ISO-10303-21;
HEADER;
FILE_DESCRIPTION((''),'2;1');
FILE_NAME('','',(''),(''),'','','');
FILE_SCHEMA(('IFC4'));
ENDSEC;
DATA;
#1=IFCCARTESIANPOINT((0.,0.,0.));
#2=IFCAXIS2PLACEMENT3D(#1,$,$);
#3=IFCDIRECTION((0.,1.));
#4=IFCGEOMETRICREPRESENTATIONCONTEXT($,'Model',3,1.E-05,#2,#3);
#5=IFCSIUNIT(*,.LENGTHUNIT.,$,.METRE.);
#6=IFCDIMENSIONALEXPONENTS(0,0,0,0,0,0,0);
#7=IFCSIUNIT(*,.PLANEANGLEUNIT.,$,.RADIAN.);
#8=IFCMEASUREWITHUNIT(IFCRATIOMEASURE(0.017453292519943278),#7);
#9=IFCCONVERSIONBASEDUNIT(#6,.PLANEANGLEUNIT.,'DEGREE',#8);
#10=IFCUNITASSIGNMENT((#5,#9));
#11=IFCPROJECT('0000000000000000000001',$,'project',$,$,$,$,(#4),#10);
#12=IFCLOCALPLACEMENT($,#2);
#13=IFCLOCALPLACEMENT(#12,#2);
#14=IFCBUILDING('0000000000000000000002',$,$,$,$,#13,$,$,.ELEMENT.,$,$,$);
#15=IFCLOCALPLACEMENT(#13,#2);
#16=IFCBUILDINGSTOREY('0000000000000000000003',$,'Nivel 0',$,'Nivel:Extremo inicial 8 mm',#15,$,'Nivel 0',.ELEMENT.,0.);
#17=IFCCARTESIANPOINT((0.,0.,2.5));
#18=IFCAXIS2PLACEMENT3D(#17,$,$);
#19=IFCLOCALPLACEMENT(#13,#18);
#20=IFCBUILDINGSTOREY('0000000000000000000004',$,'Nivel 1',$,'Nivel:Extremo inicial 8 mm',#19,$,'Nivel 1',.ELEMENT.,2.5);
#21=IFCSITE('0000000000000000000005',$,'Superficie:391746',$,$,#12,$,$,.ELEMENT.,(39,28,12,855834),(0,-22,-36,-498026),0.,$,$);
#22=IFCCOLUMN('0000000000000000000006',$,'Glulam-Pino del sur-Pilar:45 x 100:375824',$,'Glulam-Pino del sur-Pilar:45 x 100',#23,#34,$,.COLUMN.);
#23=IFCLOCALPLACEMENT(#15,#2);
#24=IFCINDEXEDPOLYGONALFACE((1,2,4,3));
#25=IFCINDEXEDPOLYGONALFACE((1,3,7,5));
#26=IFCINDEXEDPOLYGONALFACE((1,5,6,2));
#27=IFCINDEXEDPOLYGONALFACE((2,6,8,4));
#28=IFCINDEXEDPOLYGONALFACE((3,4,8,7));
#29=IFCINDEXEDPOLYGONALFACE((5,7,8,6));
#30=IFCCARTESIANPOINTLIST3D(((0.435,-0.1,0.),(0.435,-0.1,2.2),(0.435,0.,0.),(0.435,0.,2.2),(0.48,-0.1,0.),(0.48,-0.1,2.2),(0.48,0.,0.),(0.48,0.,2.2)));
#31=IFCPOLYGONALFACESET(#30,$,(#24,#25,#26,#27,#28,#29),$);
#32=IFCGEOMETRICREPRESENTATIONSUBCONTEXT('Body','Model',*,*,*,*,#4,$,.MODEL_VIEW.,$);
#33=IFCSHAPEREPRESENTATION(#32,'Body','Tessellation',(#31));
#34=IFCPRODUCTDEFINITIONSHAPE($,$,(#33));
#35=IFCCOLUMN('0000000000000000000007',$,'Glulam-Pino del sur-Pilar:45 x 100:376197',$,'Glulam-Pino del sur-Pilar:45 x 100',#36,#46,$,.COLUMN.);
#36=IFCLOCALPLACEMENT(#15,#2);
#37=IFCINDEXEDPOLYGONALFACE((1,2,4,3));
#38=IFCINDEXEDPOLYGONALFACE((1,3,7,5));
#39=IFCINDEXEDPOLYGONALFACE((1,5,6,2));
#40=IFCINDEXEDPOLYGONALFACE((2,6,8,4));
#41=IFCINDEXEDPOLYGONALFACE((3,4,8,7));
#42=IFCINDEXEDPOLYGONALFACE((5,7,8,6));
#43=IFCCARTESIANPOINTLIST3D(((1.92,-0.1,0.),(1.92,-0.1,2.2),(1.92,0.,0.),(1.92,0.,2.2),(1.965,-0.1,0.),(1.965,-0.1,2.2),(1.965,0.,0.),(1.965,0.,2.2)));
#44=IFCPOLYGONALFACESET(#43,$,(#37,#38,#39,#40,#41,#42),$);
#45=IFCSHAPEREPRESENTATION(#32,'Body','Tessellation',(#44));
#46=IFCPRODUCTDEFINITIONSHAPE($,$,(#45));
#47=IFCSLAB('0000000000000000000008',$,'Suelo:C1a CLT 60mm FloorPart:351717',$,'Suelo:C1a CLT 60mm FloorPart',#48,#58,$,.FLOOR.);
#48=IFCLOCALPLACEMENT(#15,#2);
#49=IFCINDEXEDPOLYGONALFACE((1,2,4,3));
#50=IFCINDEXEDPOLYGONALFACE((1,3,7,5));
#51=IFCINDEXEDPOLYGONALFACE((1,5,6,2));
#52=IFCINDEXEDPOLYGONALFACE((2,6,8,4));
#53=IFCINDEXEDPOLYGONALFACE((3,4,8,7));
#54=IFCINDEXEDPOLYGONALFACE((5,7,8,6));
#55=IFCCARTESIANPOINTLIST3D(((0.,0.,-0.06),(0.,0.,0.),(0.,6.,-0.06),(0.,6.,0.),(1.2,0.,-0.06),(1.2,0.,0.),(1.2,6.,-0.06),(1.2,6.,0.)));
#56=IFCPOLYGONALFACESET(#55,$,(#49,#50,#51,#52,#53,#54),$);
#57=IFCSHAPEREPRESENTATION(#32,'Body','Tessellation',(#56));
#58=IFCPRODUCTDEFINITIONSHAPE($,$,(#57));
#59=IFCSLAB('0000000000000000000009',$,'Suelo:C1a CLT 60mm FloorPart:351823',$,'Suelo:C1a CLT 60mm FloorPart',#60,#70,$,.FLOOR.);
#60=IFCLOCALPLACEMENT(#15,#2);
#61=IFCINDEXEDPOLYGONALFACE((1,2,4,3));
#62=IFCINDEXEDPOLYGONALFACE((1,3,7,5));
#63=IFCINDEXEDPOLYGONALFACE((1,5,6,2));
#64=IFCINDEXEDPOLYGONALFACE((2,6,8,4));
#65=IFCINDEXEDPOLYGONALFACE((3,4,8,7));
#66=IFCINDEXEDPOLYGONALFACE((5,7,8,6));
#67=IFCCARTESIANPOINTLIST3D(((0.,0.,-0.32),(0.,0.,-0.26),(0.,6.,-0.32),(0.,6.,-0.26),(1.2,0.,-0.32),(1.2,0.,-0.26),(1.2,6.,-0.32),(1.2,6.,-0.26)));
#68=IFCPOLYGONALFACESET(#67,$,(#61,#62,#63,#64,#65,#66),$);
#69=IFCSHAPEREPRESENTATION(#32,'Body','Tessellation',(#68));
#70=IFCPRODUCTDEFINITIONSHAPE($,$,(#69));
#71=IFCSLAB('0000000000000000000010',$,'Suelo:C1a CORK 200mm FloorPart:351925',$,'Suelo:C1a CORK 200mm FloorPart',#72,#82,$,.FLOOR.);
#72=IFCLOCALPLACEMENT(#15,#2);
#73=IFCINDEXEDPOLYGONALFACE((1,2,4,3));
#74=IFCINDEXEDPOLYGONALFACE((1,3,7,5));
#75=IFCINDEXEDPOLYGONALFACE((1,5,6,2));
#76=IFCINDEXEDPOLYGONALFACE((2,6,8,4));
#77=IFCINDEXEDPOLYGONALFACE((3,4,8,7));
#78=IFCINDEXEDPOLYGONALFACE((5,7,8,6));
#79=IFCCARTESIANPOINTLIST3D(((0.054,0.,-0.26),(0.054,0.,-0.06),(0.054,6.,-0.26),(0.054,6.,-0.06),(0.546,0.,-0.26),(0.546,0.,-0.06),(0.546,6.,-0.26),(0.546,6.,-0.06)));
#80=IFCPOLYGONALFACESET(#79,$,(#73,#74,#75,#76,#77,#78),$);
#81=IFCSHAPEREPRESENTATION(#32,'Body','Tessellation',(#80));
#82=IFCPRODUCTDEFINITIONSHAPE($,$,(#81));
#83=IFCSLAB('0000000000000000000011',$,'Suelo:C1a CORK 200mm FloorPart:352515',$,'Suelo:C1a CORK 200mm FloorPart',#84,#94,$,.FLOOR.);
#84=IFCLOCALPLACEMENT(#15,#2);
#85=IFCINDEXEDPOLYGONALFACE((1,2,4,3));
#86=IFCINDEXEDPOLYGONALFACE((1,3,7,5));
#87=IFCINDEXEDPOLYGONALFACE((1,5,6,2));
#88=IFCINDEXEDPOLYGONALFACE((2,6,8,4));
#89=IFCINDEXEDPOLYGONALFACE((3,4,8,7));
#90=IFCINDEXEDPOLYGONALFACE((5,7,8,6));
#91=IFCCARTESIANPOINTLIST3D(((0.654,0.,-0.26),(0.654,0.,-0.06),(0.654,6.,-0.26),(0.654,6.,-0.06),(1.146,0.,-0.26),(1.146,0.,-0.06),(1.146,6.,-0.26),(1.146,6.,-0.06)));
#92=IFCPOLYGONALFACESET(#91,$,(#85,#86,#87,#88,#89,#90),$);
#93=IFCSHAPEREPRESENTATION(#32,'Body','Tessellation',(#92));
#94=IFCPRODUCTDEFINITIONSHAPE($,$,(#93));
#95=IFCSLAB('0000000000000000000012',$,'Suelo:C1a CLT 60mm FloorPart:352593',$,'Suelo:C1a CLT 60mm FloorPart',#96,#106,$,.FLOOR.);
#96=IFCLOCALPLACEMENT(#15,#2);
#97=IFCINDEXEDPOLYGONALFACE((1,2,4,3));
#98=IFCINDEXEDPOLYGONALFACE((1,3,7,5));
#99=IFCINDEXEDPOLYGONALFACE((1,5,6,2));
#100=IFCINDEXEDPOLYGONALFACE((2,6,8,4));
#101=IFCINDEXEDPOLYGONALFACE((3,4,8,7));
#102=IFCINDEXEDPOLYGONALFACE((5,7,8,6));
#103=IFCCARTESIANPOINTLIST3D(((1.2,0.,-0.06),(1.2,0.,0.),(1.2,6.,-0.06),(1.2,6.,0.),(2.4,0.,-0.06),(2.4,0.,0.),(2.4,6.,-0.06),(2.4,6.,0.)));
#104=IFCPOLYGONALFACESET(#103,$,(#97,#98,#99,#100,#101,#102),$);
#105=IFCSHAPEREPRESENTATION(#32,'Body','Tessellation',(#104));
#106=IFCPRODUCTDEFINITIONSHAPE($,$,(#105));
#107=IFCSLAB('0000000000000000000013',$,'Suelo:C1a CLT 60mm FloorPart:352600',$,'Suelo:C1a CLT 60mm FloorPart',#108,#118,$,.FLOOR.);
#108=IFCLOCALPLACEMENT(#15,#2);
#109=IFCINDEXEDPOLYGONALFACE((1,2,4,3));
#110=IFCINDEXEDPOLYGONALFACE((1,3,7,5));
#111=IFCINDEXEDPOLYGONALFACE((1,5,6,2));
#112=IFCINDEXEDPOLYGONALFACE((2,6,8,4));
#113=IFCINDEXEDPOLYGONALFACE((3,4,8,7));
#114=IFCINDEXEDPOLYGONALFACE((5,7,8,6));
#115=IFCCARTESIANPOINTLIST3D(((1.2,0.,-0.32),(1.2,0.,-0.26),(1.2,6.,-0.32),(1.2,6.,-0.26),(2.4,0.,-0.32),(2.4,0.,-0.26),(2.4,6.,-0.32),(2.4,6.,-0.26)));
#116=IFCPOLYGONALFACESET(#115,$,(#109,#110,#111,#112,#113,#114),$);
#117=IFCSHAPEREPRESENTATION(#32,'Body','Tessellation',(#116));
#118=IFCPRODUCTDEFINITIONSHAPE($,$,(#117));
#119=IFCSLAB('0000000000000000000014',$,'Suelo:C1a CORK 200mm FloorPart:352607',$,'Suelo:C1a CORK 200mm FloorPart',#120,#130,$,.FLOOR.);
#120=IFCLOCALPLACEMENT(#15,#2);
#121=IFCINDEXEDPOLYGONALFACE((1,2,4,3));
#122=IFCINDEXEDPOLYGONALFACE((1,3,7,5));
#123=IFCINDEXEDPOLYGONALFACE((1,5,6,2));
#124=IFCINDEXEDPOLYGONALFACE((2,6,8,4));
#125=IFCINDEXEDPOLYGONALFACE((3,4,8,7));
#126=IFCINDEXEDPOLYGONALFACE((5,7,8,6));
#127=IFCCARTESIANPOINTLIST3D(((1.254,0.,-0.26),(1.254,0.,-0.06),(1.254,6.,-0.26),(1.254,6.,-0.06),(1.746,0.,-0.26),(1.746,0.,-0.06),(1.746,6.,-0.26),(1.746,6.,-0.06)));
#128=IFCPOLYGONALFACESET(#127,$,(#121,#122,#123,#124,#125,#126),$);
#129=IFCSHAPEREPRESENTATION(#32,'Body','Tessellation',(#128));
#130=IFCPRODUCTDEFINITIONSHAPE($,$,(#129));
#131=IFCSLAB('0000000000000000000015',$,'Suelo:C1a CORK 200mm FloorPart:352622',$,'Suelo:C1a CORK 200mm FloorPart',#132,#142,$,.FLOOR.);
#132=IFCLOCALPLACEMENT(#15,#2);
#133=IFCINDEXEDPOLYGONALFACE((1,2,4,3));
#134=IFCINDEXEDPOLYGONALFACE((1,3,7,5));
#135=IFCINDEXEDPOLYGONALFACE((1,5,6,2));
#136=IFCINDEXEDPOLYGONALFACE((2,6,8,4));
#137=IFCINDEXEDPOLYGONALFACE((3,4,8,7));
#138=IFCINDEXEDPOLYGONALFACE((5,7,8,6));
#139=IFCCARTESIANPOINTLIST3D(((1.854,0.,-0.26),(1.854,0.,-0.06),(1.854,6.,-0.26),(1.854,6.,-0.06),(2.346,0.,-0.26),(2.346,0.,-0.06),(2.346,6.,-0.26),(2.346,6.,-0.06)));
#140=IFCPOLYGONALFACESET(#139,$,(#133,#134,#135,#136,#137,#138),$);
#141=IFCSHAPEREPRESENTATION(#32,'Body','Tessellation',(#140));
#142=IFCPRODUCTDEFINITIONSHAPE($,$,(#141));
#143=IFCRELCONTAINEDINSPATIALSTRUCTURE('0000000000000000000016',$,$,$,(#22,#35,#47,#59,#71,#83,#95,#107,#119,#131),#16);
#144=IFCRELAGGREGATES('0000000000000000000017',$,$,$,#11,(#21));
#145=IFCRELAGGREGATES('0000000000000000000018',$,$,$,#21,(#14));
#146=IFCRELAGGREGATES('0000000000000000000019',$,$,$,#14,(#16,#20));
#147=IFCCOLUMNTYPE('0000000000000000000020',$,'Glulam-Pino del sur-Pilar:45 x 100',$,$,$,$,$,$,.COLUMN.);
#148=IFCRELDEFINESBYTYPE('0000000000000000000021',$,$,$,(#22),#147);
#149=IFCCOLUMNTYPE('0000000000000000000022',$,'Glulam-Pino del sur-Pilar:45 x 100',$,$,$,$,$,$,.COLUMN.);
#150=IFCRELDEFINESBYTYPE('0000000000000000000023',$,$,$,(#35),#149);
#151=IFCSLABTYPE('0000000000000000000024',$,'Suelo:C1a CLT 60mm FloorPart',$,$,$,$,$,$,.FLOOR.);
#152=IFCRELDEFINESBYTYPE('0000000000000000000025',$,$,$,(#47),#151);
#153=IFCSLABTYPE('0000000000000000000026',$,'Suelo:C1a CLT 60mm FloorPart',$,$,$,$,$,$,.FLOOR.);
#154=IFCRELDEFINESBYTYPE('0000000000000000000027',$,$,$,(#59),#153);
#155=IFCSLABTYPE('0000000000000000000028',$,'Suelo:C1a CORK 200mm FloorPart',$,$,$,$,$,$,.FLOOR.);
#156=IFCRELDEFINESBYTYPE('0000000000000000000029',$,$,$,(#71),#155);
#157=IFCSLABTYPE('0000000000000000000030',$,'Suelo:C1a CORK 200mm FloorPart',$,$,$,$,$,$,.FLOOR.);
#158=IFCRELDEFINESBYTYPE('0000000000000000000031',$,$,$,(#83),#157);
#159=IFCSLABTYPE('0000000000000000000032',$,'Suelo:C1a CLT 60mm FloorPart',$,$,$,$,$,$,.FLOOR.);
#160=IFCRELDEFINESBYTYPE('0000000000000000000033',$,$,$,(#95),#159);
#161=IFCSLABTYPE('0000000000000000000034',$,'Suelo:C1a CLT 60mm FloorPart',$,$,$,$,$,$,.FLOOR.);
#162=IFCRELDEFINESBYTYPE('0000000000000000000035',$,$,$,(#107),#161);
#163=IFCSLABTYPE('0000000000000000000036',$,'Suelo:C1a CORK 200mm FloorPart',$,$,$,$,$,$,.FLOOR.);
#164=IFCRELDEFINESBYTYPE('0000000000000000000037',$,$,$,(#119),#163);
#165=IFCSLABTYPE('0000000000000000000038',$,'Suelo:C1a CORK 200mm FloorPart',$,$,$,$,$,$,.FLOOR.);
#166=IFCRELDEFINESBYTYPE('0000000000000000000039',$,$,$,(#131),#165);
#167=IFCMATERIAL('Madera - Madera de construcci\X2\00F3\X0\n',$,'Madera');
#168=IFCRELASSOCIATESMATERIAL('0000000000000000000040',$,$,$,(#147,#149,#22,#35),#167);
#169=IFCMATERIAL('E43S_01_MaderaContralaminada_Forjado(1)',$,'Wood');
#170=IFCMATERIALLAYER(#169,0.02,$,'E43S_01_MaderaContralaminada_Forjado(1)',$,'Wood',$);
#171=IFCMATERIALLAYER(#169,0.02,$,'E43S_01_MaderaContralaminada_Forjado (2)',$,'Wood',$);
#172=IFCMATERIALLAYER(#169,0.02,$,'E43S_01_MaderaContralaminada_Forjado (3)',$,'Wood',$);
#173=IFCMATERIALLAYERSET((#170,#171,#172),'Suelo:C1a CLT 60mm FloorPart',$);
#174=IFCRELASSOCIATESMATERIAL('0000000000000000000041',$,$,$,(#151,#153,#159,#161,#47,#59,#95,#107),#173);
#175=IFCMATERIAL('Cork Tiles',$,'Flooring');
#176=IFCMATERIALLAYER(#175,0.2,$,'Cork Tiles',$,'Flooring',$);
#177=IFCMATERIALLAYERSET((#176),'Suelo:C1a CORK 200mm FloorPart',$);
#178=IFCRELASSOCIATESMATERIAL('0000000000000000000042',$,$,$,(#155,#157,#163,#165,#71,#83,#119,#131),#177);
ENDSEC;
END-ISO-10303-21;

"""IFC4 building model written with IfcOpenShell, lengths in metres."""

from ifc_helpers import new_model, entity, si_unit, converted_unit, direction, frame, frame_2d, origin, origin_2d_with_axis, place, context, subcontext, project, spatial, polyline, segment, composite_curve, rectangle, outline, extrude, source, transform, mapped, material, layer, layer_set, layer_usage, material_profile, profile_set, profile_usage, type_object, type_shapes, element, save


model = new_model("IFC4")

# Units and contexts
model_context = context("Model", 3, precision=1e-05, world=origin(), true_north=direction((0.0, 1.0)))
body_context = subcontext(model_context, "Body", "Model", "MODEL_VIEW")
ifc_project = project(units=[si_unit("LENGTHUNIT", "METRE"), converted_unit("PLANEANGLEUNIT", "DEGREE", entity("IfcRatioMeasure", 0.017453292519943278), si_unit("PLANEANGLEUNIT", "RADIAN"), dimensions=[0, 0, 0, 0, 0, 0, 0])], contexts=[model_context])

# Site, building, storey
site_placement = place(None, origin())
site = spatial("IfcSite", under=ifc_project, at=site_placement, Name="Superficie:391746", CompositionType="ELEMENT", RefLatitude=(39, 28, 12, 855834), RefLongitude=(0, -22, -36, -498026), RefElevation=0.0)
building_placement = place(site_placement, origin())
building = spatial("IfcBuilding", under=site, at=building_placement, CompositionType="ELEMENT")
storey_1_placement = place(building_placement, origin())
storey_1 = spatial("IfcBuildingStorey", under=building, at=storey_1_placement, Name="Nivel 0", ObjectType="Nivel:Extremo inicial 8 mm", LongName="Nivel 0", CompositionType="ELEMENT", Elevation=0.0)

# Columns
ifc_material_1 = material(Name="Madera - Madera de construcción", Category="Madera")
ifc_material_profile_1 = material_profile(ifc_material_1, outline(composite_curve([segment(polyline([(0.0225, 0.05, 0.0), (0.0225, -0.05, 0.0)]), True, "CONTINUOUS"), segment(polyline([(0.0225, -0.05, 0.0), (-0.0225, -0.05, 0.0)]), True, "CONTINUOUS"), segment(polyline([(-0.0225, -0.05, 0.0), (-0.0225, 0.05, 0.0)]), True, "CONTINUOUS"), segment(polyline([(-0.0225, 0.05, 0.0), (0.0225, 0.05, 0.0)]), True, "CONTINUOUS")], self_intersect=False), kind="CURVE"), Name="45 x 100")
ifc_material_profile_2 = material_profile(ifc_material_1, outline(composite_curve([segment(polyline([(0.0225, 0.05, 2.5), (-0.0225, 0.05, 2.5)]), True, "CONTINUOUS"), segment(polyline([(-0.0225, 0.05, 2.5), (-0.0225, -0.05, 2.5)]), True, "CONTINUOUS"), segment(polyline([(-0.0225, -0.05, 2.5), (0.0225, -0.05, 2.5)]), True, "CONTINUOUS"), segment(polyline([(0.0225, -0.05, 2.5), (0.0225, 0.05, 2.5)]), True, "CONTINUOUS")], self_intersect=False), kind="CURVE"), Name="45 x 100")
ifc_profile_set = profile_set([ifc_material_profile_1, ifc_material_profile_2], Name="45 x 100")
ifc_profile_usage_1 = profile_usage(ifc_profile_set)
column_type_1 = type_object("IfcColumnType", Name="Glulam-Pino del sur-Pilar:45 x 100", PredefinedType="COLUMN", material=ifc_profile_set)
shared_shape_1 = source(origin(), body_context, "Body", "SweptSolid", [
    extrude(rectangle(XDim=0.1, YDim=0.045, at=origin_2d_with_axis()), frame((0.0, 0.0, 0.0), z_axis=(0.0, 0.0, 1.0), x_axis=(0.0, -1.0, 0.0)), (0.0, 0.0, 1.0), 2.2),
])
type_shapes(column_type_1, [shared_shape_1])
column_1_placement = place(storey_1_placement, frame((0.4575, -0.05, 0.0), z_axis=(0.0, 0.0, 1.0), x_axis=(-1.0, 0.0, 0.0)))
element("IfcColumn", 1, at=column_1_placement, inside=storey_1, type_object=column_type_1, material=ifc_profile_usage_1, Name="Glulam-Pino del sur-Pilar:45 x 100:375824", ObjectType="Glulam-Pino del sur-Pilar:45 x 100", PredefinedType="COLUMN", context=body_context, shape_type="MappedRepresentation", body=[
    mapped(shared_shape_1, transform((0.0, 0.0, 0.0), scale=1.0)),
])
ifc_profile_usage_2 = profile_usage(ifc_profile_set)
column_type_2 = type_object("IfcColumnType", Name="Glulam-Pino del sur-Pilar:45 x 100", PredefinedType="COLUMN", material=ifc_profile_set)
shared_shape_2 = source(origin(), body_context, "Body", "SweptSolid", [
    extrude(rectangle(XDim=0.1, YDim=0.045, at=origin_2d_with_axis()), frame((0.0, 0.0, 0.0), z_axis=(0.0, 0.0, 1.0), x_axis=(0.0, -1.0, 0.0)), (0.0, 0.0, 1.0), 2.2),
])
type_shapes(column_type_2, [shared_shape_2])
column_2_placement = place(storey_1_placement, frame((1.9425, -0.05, 0.0)))
element("IfcColumn", 2, at=column_2_placement, inside=storey_1, type_object=column_type_2, material=ifc_profile_usage_2, Name="Glulam-Pino del sur-Pilar:45 x 100:376197", ObjectType="Glulam-Pino del sur-Pilar:45 x 100", PredefinedType="COLUMN", context=body_context, shape_type="MappedRepresentation", body=[
    mapped(shared_shape_2, transform((0.0, 0.0, 0.0), scale=1.0)),
])

# Slabs
ifc_material_2 = material(Name="E43S_01_MaderaContralaminada_Forjado(1)", Category="Wood")
ifc_layer_1 = layer(ifc_material_2, 0.02, Name="E43S_01_MaderaContralaminada_Forjado(1)", Category="Wood")
ifc_layer_2 = layer(ifc_material_2, 0.02, Name="E43S_01_MaderaContralaminada_Forjado (2)", Category="Wood")
ifc_layer_3 = layer(ifc_material_2, 0.02, Name="E43S_01_MaderaContralaminada_Forjado (3)", Category="Wood")
ifc_layer_set_1 = layer_set([ifc_layer_1, ifc_layer_2, ifc_layer_3], Name="Suelo:C1a CLT 60mm FloorPart")
ifc_layer_usage_1 = layer_usage(ifc_layer_set_1, "AXIS3", "POSITIVE", 0.0)
slab_type_1 = type_object("IfcSlabType", Name="Suelo:C1a CLT 60mm FloorPart", PredefinedType="FLOOR", material=ifc_layer_set_1)
slab_1_placement = place(storey_1_placement, origin())
element("IfcSlab", 3, at=slab_1_placement, inside=storey_1, type_object=slab_type_1, material=ifc_layer_usage_1, Name="Suelo:C1a CLT 60mm FloorPart:351717", ObjectType="Suelo:C1a CLT 60mm FloorPart", PredefinedType="FLOOR", context=body_context, shape_type="SweptSolid", body=[
    extrude(rectangle(XDim=6.0, YDim=1.2, at=frame_2d((0.0, 0.0), x_axis=(1.0, 0.0))), frame((0.6, 3.0, 0.0), z_axis=(0.0, 0.0, -1.0), x_axis=(0.0, 1.0, 0.0)), (0.0, 0.0, 1.0), 0.06),
])
ifc_layer_usage_2 = layer_usage(ifc_layer_set_1, "AXIS3", "POSITIVE", 0.0)
slab_type_2 = type_object("IfcSlabType", Name="Suelo:C1a CLT 60mm FloorPart", PredefinedType="FLOOR", material=ifc_layer_set_1)
slab_2_placement = place(storey_1_placement, origin())
element("IfcSlab", 4, at=slab_2_placement, inside=storey_1, type_object=slab_type_2, material=ifc_layer_usage_2, Name="Suelo:C1a CLT 60mm FloorPart:351823", ObjectType="Suelo:C1a CLT 60mm FloorPart", PredefinedType="FLOOR", context=body_context, shape_type="SweptSolid", body=[
    extrude(rectangle(XDim=6.0, YDim=1.2, at=frame_2d((0.0, 0.0), x_axis=(1.0, 0.0))), frame((0.6, 3.0, -0.26), z_axis=(0.0, 0.0, -1.0), x_axis=(0.0, 1.0, 0.0)), (0.0, 0.0, 1.0), 0.06),
])
ifc_material_3 = material(Name="Cork Tiles", Category="Flooring")
ifc_layer_4 = layer(ifc_material_3, 0.2, Name="Cork Tiles", Category="Flooring")
ifc_layer_set_2 = layer_set([ifc_layer_4], Name="Suelo:C1a CORK 200mm FloorPart")
ifc_layer_usage_3 = layer_usage(ifc_layer_set_2, "AXIS3", "POSITIVE", 0.0)
slab_type_3 = type_object("IfcSlabType", Name="Suelo:C1a CORK 200mm FloorPart", PredefinedType="FLOOR", material=ifc_layer_set_2)
slab_3_placement = place(storey_1_placement, origin())
element("IfcSlab", 5, at=slab_3_placement, inside=storey_1, type_object=slab_type_3, material=ifc_layer_usage_3, Name="Suelo:C1a CORK 200mm FloorPart:351925", ObjectType="Suelo:C1a CORK 200mm FloorPart", PredefinedType="FLOOR", context=body_context, shape_type="SweptSolid", body=[
    extrude(rectangle(XDim=6.0, YDim=0.492, at=frame_2d((0.0, 0.0), x_axis=(1.0, 0.0))), frame((0.3, 3.0, -0.06), z_axis=(0.0, 0.0, -1.0), x_axis=(0.0, 1.0, 0.0)), (0.0, 0.0, 1.0), 0.2),
])
ifc_layer_usage_4 = layer_usage(ifc_layer_set_2, "AXIS3", "POSITIVE", 0.0)
slab_type_4 = type_object("IfcSlabType", Name="Suelo:C1a CORK 200mm FloorPart", PredefinedType="FLOOR", material=ifc_layer_set_2)
slab_4_placement = place(storey_1_placement, origin())
element("IfcSlab", 6, at=slab_4_placement, inside=storey_1, type_object=slab_type_4, material=ifc_layer_usage_4, Name="Suelo:C1a CORK 200mm FloorPart:352515", ObjectType="Suelo:C1a CORK 200mm FloorPart", PredefinedType="FLOOR", context=body_context, shape_type="SweptSolid", body=[
    extrude(rectangle(XDim=6.0, YDim=0.492, at=frame_2d((0.0, 0.0), x_axis=(1.0, 0.0))), frame((0.9, 3.0, -0.06), z_axis=(0.0, 0.0, -1.0), x_axis=(0.0, 1.0, 0.0)), (0.0, 0.0, 1.0), 0.2),
])
ifc_layer_usage_5 = layer_usage(ifc_layer_set_1, "AXIS3", "POSITIVE", 0.0)
slab_type_5 = type_object("IfcSlabType", Name="Suelo:C1a CLT 60mm FloorPart", PredefinedType="FLOOR", material=ifc_layer_set_1)
slab_5_placement = place(storey_1_placement, origin())
element("IfcSlab", 7, at=slab_5_placement, inside=storey_1, type_object=slab_type_5, material=ifc_layer_usage_5, Name="Suelo:C1a CLT 60mm FloorPart:352593", ObjectType="Suelo:C1a CLT 60mm FloorPart", PredefinedType="FLOOR", context=body_context, shape_type="SweptSolid", body=[
    extrude(rectangle(XDim=6.0, YDim=1.2, at=frame_2d((0.0, 0.0), x_axis=(1.0, 0.0))), frame((1.8, 3.0, 0.0), z_axis=(0.0, 0.0, -1.0), x_axis=(0.0, 1.0, 0.0)), (0.0, 0.0, 1.0), 0.06),
])
ifc_layer_usage_6 = layer_usage(ifc_layer_set_1, "AXIS3", "POSITIVE", 0.0)
slab_type_6 = type_object("IfcSlabType", Name="Suelo:C1a CLT 60mm FloorPart", PredefinedType="FLOOR", material=ifc_layer_set_1)
slab_6_placement = place(storey_1_placement, origin())
element("IfcSlab", 8, at=slab_6_placement, inside=storey_1, type_object=slab_type_6, material=ifc_layer_usage_6, Name="Suelo:C1a CLT 60mm FloorPart:352600", ObjectType="Suelo:C1a CLT 60mm FloorPart", PredefinedType="FLOOR", context=body_context, shape_type="SweptSolid", body=[
    extrude(rectangle(XDim=6.0, YDim=1.2, at=frame_2d((0.0, 0.0), x_axis=(1.0, 0.0))), frame((1.8, 3.0, -0.26), z_axis=(0.0, 0.0, -1.0), x_axis=(0.0, 1.0, 0.0)), (0.0, 0.0, 1.0), 0.06),
])
ifc_layer_usage_7 = layer_usage(ifc_layer_set_2, "AXIS3", "POSITIVE", 0.0)
slab_type_7 = type_object("IfcSlabType", Name="Suelo:C1a CORK 200mm FloorPart", PredefinedType="FLOOR", material=ifc_layer_set_2)
slab_7_placement = place(storey_1_placement, origin())
element("IfcSlab", 9, at=slab_7_placement, inside=storey_1, type_object=slab_type_7, material=ifc_layer_usage_7, Name="Suelo:C1a CORK 200mm FloorPart:352607", ObjectType="Suelo:C1a CORK 200mm FloorPart", PredefinedType="FLOOR", context=body_context, shape_type="SweptSolid", body=[
    extrude(rectangle(XDim=6.0, YDim=0.492, at=frame_2d((0.0, 0.0), x_axis=(1.0, 0.0))), frame((1.5, 3.0, -0.06), z_axis=(0.0, 0.0, -1.0), x_axis=(0.0, 1.0, 0.0)), (0.0, 0.0, 1.0), 0.2),
])
ifc_layer_usage_8 = layer_usage(ifc_layer_set_2, "AXIS3", "POSITIVE", 0.0)
slab_type_8 = type_object("IfcSlabType", Name="Suelo:C1a CORK 200mm FloorPart", PredefinedType="FLOOR", material=ifc_layer_set_2)
slab_8_placement = place(storey_1_placement, origin())
element("IfcSlab", 10, at=slab_8_placement, inside=storey_1, type_object=slab_type_8, material=ifc_layer_usage_8, Name="Suelo:C1a CORK 200mm FloorPart:352622", ObjectType="Suelo:C1a CORK 200mm FloorPart", PredefinedType="FLOOR", context=body_context, shape_type="SweptSolid", body=[
    extrude(rectangle(XDim=6.0, YDim=0.492, at=frame_2d((0.0, 0.0), x_axis=(1.0, 0.0))), frame((2.1, 3.0, -0.06), z_axis=(0.0, 0.0, -1.0), x_axis=(0.0, 1.0, 0.0)), (0.0, 0.0, 1.0), 0.2),
])

# Shared definitions
storey_2_placement = place(building_placement, frame((0.0, 0.0, 2.5)))
storey_2 = spatial("IfcBuildingStorey", under=building, at=storey_2_placement, Name="Nivel 1", ObjectType="Nivel:Extremo inicial 8 mm", LongName="Nivel 1", CompositionType="ELEMENT", Elevation=2.5)

save(model, "model.ifc")
